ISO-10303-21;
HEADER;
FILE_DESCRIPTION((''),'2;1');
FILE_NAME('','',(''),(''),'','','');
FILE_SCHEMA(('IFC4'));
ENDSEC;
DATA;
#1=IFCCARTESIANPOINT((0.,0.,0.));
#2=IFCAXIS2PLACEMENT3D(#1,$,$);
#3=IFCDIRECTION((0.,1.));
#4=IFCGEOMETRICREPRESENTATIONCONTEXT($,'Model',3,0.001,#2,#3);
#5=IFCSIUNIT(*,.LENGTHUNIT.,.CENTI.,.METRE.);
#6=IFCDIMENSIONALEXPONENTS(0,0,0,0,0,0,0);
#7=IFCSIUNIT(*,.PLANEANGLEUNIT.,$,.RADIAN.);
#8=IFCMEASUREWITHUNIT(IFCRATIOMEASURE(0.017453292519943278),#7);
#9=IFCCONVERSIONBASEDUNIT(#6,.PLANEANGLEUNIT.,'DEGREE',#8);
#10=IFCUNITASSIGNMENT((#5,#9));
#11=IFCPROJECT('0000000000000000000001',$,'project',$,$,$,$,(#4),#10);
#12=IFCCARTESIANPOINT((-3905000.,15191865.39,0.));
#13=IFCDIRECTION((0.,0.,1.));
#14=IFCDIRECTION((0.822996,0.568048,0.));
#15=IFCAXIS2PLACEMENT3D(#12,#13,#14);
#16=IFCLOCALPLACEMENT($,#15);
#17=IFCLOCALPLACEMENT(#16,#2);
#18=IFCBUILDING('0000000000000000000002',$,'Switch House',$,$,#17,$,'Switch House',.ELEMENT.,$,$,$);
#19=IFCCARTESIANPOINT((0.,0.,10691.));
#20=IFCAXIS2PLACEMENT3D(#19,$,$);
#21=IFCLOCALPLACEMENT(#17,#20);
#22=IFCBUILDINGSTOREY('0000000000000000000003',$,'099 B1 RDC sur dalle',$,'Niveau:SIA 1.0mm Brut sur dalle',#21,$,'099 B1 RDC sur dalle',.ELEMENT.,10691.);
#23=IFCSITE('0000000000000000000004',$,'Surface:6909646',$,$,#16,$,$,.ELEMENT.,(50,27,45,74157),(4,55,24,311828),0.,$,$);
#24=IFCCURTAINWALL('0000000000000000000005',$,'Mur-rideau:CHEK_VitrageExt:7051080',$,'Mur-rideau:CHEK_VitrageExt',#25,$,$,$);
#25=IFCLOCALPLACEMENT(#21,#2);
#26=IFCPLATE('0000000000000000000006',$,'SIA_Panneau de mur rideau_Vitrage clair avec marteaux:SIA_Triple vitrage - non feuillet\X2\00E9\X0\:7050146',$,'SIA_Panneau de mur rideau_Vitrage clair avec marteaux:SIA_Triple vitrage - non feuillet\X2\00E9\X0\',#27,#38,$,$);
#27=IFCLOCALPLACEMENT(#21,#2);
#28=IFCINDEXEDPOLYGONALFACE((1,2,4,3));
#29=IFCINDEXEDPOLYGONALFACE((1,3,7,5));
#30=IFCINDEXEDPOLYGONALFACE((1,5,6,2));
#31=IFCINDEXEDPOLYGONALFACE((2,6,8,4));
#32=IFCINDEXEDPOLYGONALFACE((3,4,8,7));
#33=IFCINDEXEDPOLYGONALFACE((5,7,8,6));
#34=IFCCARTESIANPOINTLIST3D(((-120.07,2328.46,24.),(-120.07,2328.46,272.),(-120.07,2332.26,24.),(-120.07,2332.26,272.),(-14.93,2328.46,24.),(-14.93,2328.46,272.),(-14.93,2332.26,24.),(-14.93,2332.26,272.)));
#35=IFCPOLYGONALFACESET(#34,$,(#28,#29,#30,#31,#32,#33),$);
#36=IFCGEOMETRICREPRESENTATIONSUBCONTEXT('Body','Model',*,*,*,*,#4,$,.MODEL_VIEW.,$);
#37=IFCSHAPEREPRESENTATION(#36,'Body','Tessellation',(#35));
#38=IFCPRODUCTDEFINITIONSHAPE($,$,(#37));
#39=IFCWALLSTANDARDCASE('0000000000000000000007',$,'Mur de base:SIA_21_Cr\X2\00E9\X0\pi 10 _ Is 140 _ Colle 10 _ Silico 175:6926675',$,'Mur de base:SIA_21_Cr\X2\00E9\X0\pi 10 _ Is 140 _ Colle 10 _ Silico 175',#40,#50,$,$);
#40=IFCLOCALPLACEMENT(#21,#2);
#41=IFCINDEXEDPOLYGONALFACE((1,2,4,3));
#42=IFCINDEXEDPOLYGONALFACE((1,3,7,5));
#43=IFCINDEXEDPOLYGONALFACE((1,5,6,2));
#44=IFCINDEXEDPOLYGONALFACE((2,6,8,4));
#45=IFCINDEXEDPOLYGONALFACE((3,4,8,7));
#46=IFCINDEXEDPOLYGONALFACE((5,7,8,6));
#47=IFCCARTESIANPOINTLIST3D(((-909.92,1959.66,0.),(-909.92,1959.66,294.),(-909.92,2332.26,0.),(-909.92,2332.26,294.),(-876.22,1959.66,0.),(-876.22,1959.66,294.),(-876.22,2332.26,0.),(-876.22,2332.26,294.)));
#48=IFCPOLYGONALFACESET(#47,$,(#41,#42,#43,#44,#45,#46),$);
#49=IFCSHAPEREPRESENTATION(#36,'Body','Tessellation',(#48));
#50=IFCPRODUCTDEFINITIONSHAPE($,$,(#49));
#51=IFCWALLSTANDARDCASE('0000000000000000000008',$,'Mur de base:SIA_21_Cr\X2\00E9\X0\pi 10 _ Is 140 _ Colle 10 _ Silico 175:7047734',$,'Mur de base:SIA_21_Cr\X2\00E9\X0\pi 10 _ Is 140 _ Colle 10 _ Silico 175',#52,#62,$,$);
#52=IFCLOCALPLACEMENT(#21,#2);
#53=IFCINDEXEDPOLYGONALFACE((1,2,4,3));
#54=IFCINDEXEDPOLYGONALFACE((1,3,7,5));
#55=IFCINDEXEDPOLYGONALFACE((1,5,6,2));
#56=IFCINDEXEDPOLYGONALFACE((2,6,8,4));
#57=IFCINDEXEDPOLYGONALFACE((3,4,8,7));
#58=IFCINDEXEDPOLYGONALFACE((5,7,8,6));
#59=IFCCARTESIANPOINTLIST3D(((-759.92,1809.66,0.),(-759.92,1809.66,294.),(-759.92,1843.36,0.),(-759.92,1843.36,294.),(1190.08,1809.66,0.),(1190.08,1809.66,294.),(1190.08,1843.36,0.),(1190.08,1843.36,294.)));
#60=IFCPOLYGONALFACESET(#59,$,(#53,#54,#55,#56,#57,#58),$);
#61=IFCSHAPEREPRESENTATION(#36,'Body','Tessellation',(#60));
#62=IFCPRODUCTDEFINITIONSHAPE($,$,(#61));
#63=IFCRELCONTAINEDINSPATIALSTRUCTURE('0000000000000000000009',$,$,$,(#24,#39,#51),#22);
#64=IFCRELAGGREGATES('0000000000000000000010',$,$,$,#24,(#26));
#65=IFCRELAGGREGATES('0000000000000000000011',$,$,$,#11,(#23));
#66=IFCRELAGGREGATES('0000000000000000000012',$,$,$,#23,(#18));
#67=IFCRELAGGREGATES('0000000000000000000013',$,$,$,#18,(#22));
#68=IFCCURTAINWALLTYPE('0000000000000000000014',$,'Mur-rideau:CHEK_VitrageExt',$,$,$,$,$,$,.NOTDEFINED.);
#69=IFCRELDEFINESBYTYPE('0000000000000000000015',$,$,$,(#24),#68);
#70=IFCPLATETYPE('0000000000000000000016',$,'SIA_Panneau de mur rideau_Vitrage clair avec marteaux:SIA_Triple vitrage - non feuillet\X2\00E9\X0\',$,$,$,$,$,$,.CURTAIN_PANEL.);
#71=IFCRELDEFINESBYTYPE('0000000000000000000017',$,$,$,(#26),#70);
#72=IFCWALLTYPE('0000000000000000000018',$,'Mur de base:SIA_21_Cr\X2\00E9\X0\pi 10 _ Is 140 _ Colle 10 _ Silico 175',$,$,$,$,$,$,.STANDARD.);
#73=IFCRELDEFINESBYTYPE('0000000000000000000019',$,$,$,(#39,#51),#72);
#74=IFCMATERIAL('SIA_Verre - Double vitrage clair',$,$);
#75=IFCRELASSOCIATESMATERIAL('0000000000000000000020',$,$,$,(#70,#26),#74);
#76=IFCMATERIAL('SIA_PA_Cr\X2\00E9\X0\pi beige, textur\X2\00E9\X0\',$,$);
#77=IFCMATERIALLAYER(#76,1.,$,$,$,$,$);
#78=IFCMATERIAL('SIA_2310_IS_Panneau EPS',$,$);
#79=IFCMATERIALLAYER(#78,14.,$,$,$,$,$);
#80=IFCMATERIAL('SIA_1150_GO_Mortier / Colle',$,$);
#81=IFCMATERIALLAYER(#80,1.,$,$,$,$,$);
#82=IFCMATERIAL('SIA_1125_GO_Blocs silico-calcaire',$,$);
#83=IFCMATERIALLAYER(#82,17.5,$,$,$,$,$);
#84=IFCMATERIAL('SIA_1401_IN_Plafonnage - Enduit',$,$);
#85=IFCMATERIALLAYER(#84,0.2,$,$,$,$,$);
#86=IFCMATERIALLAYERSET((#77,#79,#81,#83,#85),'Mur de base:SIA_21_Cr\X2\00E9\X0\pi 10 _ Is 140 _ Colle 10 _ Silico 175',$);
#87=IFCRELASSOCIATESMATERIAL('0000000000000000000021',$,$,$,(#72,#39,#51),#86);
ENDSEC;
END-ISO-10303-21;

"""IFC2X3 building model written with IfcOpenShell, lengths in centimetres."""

from ifc_helpers import new_model, entity, si_unit, converted_unit, direction, frame, frame_2d, origin, origin_2d_with_axis, place, context, subcontext, project, spatial, polyline, rectangle, extrude, clip, bounded_halfspace, source, transform, mapped, material, layer, layer_set, layer_usage, type_object, type_shapes, element, aggregate, save


model = new_model("IFC2X3")

# Units and contexts
model_context = context("Model", 3, precision=0.001, world=origin(), true_north=direction((0.0, 1.0)))
body_context = subcontext(model_context, "Body", "Model", "MODEL_VIEW")
ifc_project = project(units=[si_unit("LENGTHUNIT", "METRE", prefix="CENTI"), converted_unit("PLANEANGLEUNIT", "DEGREE", entity("IfcRatioMeasure", 0.017453292519943278), si_unit("PLANEANGLEUNIT", "RADIAN"), dimensions=[0, 0, 0, 0, 0, 0, 0])], contexts=[model_context])

# Site, building, storey
site_placement = place(None, frame((-3905000.0, 15191865.39, 0.0), z_axis=(0.0, 0.0, 1.0), x_axis=(0.822996, 0.568048, 0.0)))
site = spatial("IfcSite", under=ifc_project, at=site_placement, Name="Surface:6909646", CompositionType="ELEMENT", RefLatitude=(50, 27, 45, 74157), RefLongitude=(4, 55, 24, 311828), RefElevation=0.0)
building_placement = place(site_placement, origin())
building = spatial("IfcBuilding", under=site, at=building_placement, Name="Switch House", LongName="Switch House", CompositionType="ELEMENT")
storey_placement = place(building_placement, frame((0.0, 0.0, 10691.0)))
storey = spatial("IfcBuildingStorey", under=building, at=storey_placement, Name="099 B1 RDC sur dalle", ObjectType="Niveau:SIA 1.0mm Brut sur dalle", LongName="099 B1 RDC sur dalle", CompositionType="ELEMENT", Elevation=10691.0)

# Shared definitions
curtain_wall_type = type_object("IfcCurtainWallType", Name="Mur-rideau:CHEK_VitrageExt", PredefinedType="NOTDEFINED")

# Curtain wall
curtain_wall_1_placement = place(storey_placement, frame((0.0, 0.0, -10691.0)))
curtain_wall_1 = element("IfcCurtainWall", 1, at=curtain_wall_1_placement, inside=storey, type_object=curtain_wall_type, Name="Mur-rideau:CHEK_VitrageExt:7051080", ObjectType="Mur-rideau:CHEK_VitrageExt")

# Plate
ifc_material_1 = material(Name="SIA_Verre - Double vitrage clair")
plate_type_1 = type_object("IfcPlateType", Name="SIA_Panneau de mur rideau_Vitrage clair avec marteaux:SIA_Triple vitrage - non feuilleté", PredefinedType="CURTAIN_PANEL", material=ifc_material_1)
shared_shape_1 = source(origin(), body_context, "Body", "SweptSolid", [
    extrude(rectangle(XDim=3.8, YDim=105.14, at=origin_2d_with_axis()), frame((0.0, -1.9, 0.0), z_axis=(0.0, 0.0, 1.0), x_axis=(0.0, 1.0, 0.0)), (0.0, 0.0, 1.0), 248.0),
])
type_shapes(plate_type_1, [shared_shape_1])
plate_1_placement = place(curtain_wall_1_placement, frame((-67.5, 2332.26, 10715.0)))
plate_1 = element("IfcPlate", 2, at=plate_1_placement, type_object=plate_type_1, material=ifc_material_1, Name="SIA_Panneau de mur rideau_Vitrage clair avec marteaux:SIA_Triple vitrage - non feuilleté:7050146", ObjectType="SIA_Panneau de mur rideau_Vitrage clair avec marteaux:SIA_Triple vitrage - non feuilleté", context=body_context, shape_type="MappedRepresentation", body=[
    mapped(shared_shape_1, transform((0.0, 0.0, 0.0), scale=1.0)),
])
aggregate(curtain_wall_1, [plate_1])

# Walls
ifc_material_2 = material(Name="SIA_PA_Crépi beige, texturé")
ifc_layer_1 = layer(ifc_material_2, 1.0)
ifc_material_3 = material(Name="SIA_2310_IS_Panneau EPS")
ifc_layer_2 = layer(ifc_material_3, 14.0)
ifc_material_4 = material(Name="SIA_1150_GO_Mortier / Colle")
ifc_layer_3 = layer(ifc_material_4, 1.0)
ifc_material_5 = material(Name="SIA_1125_GO_Blocs silico-calcaire")
ifc_layer_4 = layer(ifc_material_5, 17.5)
ifc_material_6 = material(Name="SIA_1401_IN_Plafonnage - Enduit")
ifc_layer_5 = layer(ifc_material_6, 0.2)
ifc_layer_set_1 = layer_set([ifc_layer_1, ifc_layer_2, ifc_layer_3, ifc_layer_4, ifc_layer_5], Name="Mur de base:SIA_21_Crépi 10 _ Is 140 _ Colle 10 _ Silico 175")
ifc_layer_usage_1 = layer_usage(ifc_layer_set_1, "AXIS2", "NEGATIVE", 16.85)
wall_type = type_object("IfcWallType", Name="Mur de base:SIA_21_Crépi 10 _ Is 140 _ Colle 10 _ Silico 175", PredefinedType="STANDARD", material=ifc_layer_set_1)
wall_1_placement = place(storey_placement, frame((-893.07, 1959.66, 0.0), z_axis=(0.0, 0.0, 1.0), x_axis=(0.0, 1.0, 0.0)))
element("IfcWallStandardCase", 3, at=wall_1_placement, inside=storey, type_object=wall_type, material=ifc_layer_usage_1, Name="Mur de base:SIA_21_Crépi 10 _ Is 140 _ Colle 10 _ Silico 175:6926675", ObjectType="Mur de base:SIA_21_Crépi 10 _ Is 140 _ Colle 10 _ Silico 175", context=body_context, shape_type="Clipping", body=[
    clip(extrude(rectangle(XDim=372.6, YDim=33.7, at=frame_2d((186.3, 0.0), x_axis=(-1.0, 0.0))), origin(), (0.0, 0.0, 1.0), 294.0), bounded_halfspace(frame((0.0, -16.85, 294.0), z_axis=(0.0, 0.0, -1.0), x_axis=(-1.0, 0.0, 0.0)), True, frame((0.0, -16.85, 294.0)), polyline([(0.0, 0.0), (372.6, 0.0), (372.6, 33.7), (0.0, 33.7), (0.0, 0.0)]))),
])
ifc_layer_usage_2 = layer_usage(ifc_layer_set_1, "AXIS2", "POSITIVE", -16.85)
wall_2_placement = place(storey_placement, frame((-759.92, 1826.51, 0.0)))
element("IfcWallStandardCase", 4, at=wall_2_placement, inside=storey, type_object=wall_type, material=ifc_layer_usage_2, Name="Mur de base:SIA_21_Crépi 10 _ Is 140 _ Colle 10 _ Silico 175:7047734", ObjectType="Mur de base:SIA_21_Crépi 10 _ Is 140 _ Colle 10 _ Silico 175", context=body_context, shape_type="Clipping", body=[
    clip(extrude(rectangle(XDim=1950.0, YDim=33.7, at=frame_2d((975.0, 0.0), x_axis=(-1.0, 0.0))), origin(), (0.0, 0.0, 1.0), 294.0), bounded_halfspace(frame((0.0, -16.85, 294.0), z_axis=(0.0, 0.0, -1.0), x_axis=(0.0, -1.0, 0.0)), True, frame((0.0, -16.85, 294.0)), polyline([(0.0, 0.0), (1950.0, 0.0), (1950.0, 33.7), (0.0, 33.7), (0.0, 0.0)]))),
])

save(model, "model.ifc")
